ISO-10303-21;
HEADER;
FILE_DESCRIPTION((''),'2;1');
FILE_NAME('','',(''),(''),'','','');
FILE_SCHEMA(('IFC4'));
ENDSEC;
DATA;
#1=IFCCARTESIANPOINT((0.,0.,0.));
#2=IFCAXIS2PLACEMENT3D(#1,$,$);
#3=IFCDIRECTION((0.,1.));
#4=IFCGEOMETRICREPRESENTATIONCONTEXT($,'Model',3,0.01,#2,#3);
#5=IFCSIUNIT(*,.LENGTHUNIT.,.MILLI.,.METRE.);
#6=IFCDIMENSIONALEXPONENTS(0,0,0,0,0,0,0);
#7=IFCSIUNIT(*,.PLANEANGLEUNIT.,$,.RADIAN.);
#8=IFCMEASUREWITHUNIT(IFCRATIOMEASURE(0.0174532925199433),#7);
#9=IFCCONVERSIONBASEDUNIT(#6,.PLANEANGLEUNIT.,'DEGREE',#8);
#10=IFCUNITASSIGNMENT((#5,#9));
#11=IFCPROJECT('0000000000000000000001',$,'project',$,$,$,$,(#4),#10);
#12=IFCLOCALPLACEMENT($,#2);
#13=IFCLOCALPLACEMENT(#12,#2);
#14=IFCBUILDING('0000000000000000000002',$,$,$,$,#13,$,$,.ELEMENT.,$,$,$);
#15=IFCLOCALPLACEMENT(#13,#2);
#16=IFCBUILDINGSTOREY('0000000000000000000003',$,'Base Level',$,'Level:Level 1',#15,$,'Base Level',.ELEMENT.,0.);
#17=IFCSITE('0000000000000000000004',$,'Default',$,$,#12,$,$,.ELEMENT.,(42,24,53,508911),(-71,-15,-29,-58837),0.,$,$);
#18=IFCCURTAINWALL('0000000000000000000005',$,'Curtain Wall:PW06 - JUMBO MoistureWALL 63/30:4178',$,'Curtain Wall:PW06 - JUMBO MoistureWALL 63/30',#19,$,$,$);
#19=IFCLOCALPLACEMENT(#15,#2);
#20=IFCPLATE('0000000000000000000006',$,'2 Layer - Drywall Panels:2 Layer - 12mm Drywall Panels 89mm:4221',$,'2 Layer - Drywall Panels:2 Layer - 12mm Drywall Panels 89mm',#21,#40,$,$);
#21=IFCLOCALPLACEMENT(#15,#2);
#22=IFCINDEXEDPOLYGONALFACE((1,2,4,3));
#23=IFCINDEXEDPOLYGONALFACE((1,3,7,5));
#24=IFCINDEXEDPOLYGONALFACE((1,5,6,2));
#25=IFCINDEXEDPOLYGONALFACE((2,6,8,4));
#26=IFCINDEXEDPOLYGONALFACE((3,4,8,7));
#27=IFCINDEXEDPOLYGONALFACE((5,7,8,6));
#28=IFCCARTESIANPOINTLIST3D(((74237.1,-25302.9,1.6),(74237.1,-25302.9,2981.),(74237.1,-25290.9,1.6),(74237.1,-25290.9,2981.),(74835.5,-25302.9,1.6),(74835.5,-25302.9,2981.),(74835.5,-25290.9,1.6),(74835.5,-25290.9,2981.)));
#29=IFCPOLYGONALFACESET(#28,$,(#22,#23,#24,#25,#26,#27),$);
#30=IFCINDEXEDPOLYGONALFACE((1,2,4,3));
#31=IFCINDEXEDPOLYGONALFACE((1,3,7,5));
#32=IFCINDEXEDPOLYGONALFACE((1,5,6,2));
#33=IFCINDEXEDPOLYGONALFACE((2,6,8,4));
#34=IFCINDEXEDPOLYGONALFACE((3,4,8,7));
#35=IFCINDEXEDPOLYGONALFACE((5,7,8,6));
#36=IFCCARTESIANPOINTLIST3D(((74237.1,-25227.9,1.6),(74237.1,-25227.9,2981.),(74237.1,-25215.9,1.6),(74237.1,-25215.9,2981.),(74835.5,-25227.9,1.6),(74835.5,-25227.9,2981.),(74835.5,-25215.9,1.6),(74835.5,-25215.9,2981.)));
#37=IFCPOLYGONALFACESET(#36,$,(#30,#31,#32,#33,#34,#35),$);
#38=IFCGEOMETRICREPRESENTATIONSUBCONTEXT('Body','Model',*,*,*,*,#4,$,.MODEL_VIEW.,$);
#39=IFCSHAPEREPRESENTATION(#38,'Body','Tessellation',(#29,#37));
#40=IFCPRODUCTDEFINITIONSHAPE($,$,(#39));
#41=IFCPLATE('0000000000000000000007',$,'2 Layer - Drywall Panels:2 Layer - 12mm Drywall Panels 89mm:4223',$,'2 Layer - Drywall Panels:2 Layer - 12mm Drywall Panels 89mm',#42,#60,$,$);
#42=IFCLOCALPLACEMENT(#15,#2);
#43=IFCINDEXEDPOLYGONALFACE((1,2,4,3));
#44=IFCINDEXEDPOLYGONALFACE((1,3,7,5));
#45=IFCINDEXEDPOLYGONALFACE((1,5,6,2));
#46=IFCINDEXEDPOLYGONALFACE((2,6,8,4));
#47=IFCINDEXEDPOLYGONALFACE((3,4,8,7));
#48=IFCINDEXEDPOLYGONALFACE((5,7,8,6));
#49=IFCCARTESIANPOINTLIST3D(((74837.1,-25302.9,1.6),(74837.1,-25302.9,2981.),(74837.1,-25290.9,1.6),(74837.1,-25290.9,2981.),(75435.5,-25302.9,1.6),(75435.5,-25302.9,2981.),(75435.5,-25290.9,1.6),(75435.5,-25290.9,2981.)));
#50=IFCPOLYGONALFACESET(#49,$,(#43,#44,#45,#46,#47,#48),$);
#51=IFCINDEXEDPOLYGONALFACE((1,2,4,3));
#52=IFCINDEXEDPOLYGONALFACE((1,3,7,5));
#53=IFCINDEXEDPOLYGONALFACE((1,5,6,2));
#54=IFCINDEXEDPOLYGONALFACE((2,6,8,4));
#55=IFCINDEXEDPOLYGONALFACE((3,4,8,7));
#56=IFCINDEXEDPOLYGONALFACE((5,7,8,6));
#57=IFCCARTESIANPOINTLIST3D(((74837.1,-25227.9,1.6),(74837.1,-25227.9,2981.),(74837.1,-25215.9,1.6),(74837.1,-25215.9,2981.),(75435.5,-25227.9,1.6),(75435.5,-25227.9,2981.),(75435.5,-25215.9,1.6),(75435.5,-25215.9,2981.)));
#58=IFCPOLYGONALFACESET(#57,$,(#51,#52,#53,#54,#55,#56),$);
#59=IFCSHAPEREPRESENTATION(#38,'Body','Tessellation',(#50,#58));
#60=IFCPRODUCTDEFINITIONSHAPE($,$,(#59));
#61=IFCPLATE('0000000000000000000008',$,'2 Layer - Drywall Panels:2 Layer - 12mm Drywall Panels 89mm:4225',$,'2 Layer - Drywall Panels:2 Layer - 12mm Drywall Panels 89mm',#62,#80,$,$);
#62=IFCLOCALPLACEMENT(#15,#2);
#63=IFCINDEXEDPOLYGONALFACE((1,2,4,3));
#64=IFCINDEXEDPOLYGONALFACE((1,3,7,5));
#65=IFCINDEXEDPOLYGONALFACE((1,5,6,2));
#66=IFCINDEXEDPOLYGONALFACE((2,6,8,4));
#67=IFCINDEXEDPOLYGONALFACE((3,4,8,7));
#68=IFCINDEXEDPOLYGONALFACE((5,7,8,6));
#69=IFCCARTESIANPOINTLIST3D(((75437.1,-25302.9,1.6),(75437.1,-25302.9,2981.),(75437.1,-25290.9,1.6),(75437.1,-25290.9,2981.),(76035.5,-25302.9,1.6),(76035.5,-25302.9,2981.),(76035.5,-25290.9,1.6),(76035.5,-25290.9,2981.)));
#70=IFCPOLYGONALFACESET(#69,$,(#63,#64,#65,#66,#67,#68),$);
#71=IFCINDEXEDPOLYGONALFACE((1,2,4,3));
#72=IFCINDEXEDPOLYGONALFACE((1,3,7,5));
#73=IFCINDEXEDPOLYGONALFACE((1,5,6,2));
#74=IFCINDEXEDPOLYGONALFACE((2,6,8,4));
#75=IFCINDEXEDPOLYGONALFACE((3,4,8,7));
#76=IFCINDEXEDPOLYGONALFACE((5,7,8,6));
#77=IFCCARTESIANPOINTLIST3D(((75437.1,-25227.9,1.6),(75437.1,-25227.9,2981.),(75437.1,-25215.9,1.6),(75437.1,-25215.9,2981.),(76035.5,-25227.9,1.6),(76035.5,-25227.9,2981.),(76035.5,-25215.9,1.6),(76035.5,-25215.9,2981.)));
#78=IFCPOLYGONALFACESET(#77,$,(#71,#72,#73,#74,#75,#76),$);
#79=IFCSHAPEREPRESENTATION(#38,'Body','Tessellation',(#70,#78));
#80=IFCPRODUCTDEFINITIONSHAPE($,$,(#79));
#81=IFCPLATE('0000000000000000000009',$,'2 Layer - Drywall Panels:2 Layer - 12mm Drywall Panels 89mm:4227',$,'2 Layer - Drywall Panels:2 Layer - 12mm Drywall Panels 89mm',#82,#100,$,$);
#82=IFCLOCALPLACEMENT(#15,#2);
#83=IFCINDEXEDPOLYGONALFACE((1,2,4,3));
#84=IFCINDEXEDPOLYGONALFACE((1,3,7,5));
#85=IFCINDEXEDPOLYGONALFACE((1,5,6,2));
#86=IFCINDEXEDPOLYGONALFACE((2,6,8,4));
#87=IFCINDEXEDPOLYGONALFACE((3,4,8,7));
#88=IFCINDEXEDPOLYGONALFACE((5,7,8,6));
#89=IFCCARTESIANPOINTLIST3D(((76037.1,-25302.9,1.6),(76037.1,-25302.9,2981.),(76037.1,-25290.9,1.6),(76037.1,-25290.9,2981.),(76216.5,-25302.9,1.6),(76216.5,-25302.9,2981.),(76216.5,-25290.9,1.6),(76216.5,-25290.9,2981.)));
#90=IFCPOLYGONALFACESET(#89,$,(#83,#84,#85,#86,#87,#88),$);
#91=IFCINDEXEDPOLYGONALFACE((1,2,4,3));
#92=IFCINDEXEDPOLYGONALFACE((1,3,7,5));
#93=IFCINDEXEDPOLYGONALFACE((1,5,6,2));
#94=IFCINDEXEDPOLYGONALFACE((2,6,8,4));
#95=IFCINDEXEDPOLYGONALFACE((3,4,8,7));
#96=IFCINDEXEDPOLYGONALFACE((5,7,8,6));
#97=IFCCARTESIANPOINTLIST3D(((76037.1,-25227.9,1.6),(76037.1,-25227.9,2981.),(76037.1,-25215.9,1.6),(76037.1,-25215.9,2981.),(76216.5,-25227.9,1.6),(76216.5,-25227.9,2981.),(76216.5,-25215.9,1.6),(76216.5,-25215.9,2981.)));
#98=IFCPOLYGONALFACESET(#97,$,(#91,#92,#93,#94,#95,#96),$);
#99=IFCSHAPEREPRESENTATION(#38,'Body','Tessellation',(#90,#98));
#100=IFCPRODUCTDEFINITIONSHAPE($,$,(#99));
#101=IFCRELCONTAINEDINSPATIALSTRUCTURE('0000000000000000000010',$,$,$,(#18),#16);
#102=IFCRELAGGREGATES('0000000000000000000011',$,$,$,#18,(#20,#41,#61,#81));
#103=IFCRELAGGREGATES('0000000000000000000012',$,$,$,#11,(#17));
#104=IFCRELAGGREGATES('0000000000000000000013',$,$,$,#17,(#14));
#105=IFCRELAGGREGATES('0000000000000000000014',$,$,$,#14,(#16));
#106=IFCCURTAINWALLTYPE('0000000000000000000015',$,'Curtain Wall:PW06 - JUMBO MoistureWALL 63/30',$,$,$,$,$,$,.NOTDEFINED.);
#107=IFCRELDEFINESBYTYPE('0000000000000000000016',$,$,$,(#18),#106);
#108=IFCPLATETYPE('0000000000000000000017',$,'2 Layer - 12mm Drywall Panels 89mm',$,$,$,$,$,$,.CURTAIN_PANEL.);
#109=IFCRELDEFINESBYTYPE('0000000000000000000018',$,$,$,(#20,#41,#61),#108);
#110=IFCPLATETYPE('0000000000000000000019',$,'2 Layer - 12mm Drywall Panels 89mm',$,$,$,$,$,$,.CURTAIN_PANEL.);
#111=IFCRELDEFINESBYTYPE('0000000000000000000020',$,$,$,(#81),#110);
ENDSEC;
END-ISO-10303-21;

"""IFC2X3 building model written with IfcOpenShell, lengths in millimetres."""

from ifc_helpers import new_model, entity, si_unit, converted_unit, direction, frame, frame_2d, origin, place, context, subcontext, project, spatial, rectangle, extrude, source, transform, mapped, type_object, type_shapes, element, aggregate, save


model = new_model("IFC2X3")

# Units and contexts
model_context = context("Model", 3, precision=0.01, world=origin(), true_north=direction((0.0, 1.0)))
body_context = subcontext(model_context, "Body", "Model", "MODEL_VIEW")
ifc_project = project(units=[si_unit("LENGTHUNIT", "METRE", prefix="MILLI"), converted_unit("PLANEANGLEUNIT", "DEGREE", entity("IfcRatioMeasure", 0.0174532925199433), si_unit("PLANEANGLEUNIT", "RADIAN"), dimensions=[0, 0, 0, 0, 0, 0, 0])], contexts=[model_context])

# Site, building, storey
site_placement = place(None, origin())
site = spatial("IfcSite", under=ifc_project, at=site_placement, Name="Default", CompositionType="ELEMENT", RefLatitude=(42, 24, 53, 508911), RefLongitude=(-71, -15, -29, -58837), RefElevation=0.0)
building_placement = place(site_placement, origin())
building = spatial("IfcBuilding", under=site, at=building_placement, CompositionType="ELEMENT")
storey_placement = place(building_placement, origin())
storey = spatial("IfcBuildingStorey", under=building, at=storey_placement, Name="Base Level", ObjectType="Level:Level 1", LongName="Base Level", CompositionType="ELEMENT", Elevation=0.0)

# Curtain wall, plates
curtain_wall_type = type_object("IfcCurtainWallType", Name="Curtain Wall:PW06 - JUMBO MoistureWALL 63/30", PredefinedType="NOTDEFINED")
curtain_wall_placement = place(building_placement, origin())
curtain_wall = element("IfcCurtainWall", 1, at=curtain_wall_placement, inside=storey, type_object=curtain_wall_type, Name="Curtain Wall:PW06 - JUMBO MoistureWALL 63/30:4178", ObjectType="Curtain Wall:PW06 - JUMBO MoistureWALL 63/30")
plate_type_1 = type_object("IfcPlateType", Name="2 Layer - 12mm Drywall Panels 89mm", PredefinedType="CURTAIN_PANEL")
shared_shape_1 = source(origin(), body_context, "Body", "SweptSolid", [
    extrude(rectangle(XDim=598.4, YDim=12.0, at=frame_2d((0.0, 0.0), x_axis=(1.0, 0.0))), frame((0.0, -37.5, 0.0), z_axis=(0.0, 0.0, 1.0), x_axis=(-1.0, 0.0, 0.0)), (0.0, 0.0, 1.0), 2979.4),
    extrude(rectangle(XDim=12.0, YDim=598.4, at=frame_2d((0.0, 0.0), x_axis=(1.0, 0.0))), frame((0.0, 37.5, 0.0), z_axis=(0.0, 0.0, 1.0), x_axis=(0.0, 1.0, 0.0)), (0.0, 0.0, 1.0), 2979.4),
])
type_shapes(plate_type_1, [shared_shape_1])
plate_1_placement = place(curtain_wall_placement, frame((74536.3, -25259.4, 1.6)))
plate_1 = element("IfcPlate", 2, at=plate_1_placement, type_object=plate_type_1, Name="2 Layer - Drywall Panels:2 Layer - 12mm Drywall Panels 89mm:4221", ObjectType="2 Layer - Drywall Panels:2 Layer - 12mm Drywall Panels 89mm", context=body_context, shape_type="MappedRepresentation", body=[
    mapped(shared_shape_1, transform((0.0, 0.0, 0.0), scale=1.0)),
])
plate_2_placement = place(curtain_wall_placement, frame((75136.3, -25259.4, 1.6)))
plate_2 = element("IfcPlate", 3, at=plate_2_placement, type_object=plate_type_1, Name="2 Layer - Drywall Panels:2 Layer - 12mm Drywall Panels 89mm:4223", ObjectType="2 Layer - Drywall Panels:2 Layer - 12mm Drywall Panels 89mm", context=body_context, shape_type="MappedRepresentation", body=[
    mapped(shared_shape_1, transform((0.0, 0.0, 0.0), scale=1.0)),
])
plate_3_placement = place(curtain_wall_placement, frame((75736.3, -25259.4, 1.6)))
plate_3 = element("IfcPlate", 4, at=plate_3_placement, type_object=plate_type_1, Name="2 Layer - Drywall Panels:2 Layer - 12mm Drywall Panels 89mm:4225", ObjectType="2 Layer - Drywall Panels:2 Layer - 12mm Drywall Panels 89mm", context=body_context, shape_type="MappedRepresentation", body=[
    mapped(shared_shape_1, transform((0.0, 0.0, 0.0), scale=1.0)),
])
plate_type_2 = type_object("IfcPlateType", Name="2 Layer - 12mm Drywall Panels 89mm", PredefinedType="CURTAIN_PANEL")
shared_shape_2 = source(origin(), body_context, "Body", "SweptSolid", [
    extrude(rectangle(XDim=179.4, YDim=12.0, at=frame_2d((0.0, 0.0), x_axis=(1.0, 0.0))), frame((0.0, -37.5, 0.0), z_axis=(0.0, 0.0, 1.0), x_axis=(-1.0, 0.0, 0.0)), (0.0, 0.0, 1.0), 2979.4),
    extrude(rectangle(XDim=12.0, YDim=179.4, at=frame_2d((0.0, 0.0), x_axis=(1.0, 0.0))), frame((0.0, 37.5, 0.0), z_axis=(0.0, 0.0, 1.0), x_axis=(0.0, 1.0, 0.0)), (0.0, 0.0, 1.0), 2979.4),
])
type_shapes(plate_type_2, [shared_shape_2])
plate_4_placement = place(curtain_wall_placement, frame((76126.8, -25259.4, 1.6)))
plate_4 = element("IfcPlate", 5, at=plate_4_placement, type_object=plate_type_2, Name="2 Layer - Drywall Panels:2 Layer - 12mm Drywall Panels 89mm:4227", ObjectType="2 Layer - Drywall Panels:2 Layer - 12mm Drywall Panels 89mm", context=body_context, shape_type="MappedRepresentation", body=[
    mapped(shared_shape_2, transform((0.0, 0.0, 0.0), scale=1.0)),
])
aggregate(curtain_wall, [plate_1, plate_2, plate_3, plate_4])

save(model, "model.ifc")
